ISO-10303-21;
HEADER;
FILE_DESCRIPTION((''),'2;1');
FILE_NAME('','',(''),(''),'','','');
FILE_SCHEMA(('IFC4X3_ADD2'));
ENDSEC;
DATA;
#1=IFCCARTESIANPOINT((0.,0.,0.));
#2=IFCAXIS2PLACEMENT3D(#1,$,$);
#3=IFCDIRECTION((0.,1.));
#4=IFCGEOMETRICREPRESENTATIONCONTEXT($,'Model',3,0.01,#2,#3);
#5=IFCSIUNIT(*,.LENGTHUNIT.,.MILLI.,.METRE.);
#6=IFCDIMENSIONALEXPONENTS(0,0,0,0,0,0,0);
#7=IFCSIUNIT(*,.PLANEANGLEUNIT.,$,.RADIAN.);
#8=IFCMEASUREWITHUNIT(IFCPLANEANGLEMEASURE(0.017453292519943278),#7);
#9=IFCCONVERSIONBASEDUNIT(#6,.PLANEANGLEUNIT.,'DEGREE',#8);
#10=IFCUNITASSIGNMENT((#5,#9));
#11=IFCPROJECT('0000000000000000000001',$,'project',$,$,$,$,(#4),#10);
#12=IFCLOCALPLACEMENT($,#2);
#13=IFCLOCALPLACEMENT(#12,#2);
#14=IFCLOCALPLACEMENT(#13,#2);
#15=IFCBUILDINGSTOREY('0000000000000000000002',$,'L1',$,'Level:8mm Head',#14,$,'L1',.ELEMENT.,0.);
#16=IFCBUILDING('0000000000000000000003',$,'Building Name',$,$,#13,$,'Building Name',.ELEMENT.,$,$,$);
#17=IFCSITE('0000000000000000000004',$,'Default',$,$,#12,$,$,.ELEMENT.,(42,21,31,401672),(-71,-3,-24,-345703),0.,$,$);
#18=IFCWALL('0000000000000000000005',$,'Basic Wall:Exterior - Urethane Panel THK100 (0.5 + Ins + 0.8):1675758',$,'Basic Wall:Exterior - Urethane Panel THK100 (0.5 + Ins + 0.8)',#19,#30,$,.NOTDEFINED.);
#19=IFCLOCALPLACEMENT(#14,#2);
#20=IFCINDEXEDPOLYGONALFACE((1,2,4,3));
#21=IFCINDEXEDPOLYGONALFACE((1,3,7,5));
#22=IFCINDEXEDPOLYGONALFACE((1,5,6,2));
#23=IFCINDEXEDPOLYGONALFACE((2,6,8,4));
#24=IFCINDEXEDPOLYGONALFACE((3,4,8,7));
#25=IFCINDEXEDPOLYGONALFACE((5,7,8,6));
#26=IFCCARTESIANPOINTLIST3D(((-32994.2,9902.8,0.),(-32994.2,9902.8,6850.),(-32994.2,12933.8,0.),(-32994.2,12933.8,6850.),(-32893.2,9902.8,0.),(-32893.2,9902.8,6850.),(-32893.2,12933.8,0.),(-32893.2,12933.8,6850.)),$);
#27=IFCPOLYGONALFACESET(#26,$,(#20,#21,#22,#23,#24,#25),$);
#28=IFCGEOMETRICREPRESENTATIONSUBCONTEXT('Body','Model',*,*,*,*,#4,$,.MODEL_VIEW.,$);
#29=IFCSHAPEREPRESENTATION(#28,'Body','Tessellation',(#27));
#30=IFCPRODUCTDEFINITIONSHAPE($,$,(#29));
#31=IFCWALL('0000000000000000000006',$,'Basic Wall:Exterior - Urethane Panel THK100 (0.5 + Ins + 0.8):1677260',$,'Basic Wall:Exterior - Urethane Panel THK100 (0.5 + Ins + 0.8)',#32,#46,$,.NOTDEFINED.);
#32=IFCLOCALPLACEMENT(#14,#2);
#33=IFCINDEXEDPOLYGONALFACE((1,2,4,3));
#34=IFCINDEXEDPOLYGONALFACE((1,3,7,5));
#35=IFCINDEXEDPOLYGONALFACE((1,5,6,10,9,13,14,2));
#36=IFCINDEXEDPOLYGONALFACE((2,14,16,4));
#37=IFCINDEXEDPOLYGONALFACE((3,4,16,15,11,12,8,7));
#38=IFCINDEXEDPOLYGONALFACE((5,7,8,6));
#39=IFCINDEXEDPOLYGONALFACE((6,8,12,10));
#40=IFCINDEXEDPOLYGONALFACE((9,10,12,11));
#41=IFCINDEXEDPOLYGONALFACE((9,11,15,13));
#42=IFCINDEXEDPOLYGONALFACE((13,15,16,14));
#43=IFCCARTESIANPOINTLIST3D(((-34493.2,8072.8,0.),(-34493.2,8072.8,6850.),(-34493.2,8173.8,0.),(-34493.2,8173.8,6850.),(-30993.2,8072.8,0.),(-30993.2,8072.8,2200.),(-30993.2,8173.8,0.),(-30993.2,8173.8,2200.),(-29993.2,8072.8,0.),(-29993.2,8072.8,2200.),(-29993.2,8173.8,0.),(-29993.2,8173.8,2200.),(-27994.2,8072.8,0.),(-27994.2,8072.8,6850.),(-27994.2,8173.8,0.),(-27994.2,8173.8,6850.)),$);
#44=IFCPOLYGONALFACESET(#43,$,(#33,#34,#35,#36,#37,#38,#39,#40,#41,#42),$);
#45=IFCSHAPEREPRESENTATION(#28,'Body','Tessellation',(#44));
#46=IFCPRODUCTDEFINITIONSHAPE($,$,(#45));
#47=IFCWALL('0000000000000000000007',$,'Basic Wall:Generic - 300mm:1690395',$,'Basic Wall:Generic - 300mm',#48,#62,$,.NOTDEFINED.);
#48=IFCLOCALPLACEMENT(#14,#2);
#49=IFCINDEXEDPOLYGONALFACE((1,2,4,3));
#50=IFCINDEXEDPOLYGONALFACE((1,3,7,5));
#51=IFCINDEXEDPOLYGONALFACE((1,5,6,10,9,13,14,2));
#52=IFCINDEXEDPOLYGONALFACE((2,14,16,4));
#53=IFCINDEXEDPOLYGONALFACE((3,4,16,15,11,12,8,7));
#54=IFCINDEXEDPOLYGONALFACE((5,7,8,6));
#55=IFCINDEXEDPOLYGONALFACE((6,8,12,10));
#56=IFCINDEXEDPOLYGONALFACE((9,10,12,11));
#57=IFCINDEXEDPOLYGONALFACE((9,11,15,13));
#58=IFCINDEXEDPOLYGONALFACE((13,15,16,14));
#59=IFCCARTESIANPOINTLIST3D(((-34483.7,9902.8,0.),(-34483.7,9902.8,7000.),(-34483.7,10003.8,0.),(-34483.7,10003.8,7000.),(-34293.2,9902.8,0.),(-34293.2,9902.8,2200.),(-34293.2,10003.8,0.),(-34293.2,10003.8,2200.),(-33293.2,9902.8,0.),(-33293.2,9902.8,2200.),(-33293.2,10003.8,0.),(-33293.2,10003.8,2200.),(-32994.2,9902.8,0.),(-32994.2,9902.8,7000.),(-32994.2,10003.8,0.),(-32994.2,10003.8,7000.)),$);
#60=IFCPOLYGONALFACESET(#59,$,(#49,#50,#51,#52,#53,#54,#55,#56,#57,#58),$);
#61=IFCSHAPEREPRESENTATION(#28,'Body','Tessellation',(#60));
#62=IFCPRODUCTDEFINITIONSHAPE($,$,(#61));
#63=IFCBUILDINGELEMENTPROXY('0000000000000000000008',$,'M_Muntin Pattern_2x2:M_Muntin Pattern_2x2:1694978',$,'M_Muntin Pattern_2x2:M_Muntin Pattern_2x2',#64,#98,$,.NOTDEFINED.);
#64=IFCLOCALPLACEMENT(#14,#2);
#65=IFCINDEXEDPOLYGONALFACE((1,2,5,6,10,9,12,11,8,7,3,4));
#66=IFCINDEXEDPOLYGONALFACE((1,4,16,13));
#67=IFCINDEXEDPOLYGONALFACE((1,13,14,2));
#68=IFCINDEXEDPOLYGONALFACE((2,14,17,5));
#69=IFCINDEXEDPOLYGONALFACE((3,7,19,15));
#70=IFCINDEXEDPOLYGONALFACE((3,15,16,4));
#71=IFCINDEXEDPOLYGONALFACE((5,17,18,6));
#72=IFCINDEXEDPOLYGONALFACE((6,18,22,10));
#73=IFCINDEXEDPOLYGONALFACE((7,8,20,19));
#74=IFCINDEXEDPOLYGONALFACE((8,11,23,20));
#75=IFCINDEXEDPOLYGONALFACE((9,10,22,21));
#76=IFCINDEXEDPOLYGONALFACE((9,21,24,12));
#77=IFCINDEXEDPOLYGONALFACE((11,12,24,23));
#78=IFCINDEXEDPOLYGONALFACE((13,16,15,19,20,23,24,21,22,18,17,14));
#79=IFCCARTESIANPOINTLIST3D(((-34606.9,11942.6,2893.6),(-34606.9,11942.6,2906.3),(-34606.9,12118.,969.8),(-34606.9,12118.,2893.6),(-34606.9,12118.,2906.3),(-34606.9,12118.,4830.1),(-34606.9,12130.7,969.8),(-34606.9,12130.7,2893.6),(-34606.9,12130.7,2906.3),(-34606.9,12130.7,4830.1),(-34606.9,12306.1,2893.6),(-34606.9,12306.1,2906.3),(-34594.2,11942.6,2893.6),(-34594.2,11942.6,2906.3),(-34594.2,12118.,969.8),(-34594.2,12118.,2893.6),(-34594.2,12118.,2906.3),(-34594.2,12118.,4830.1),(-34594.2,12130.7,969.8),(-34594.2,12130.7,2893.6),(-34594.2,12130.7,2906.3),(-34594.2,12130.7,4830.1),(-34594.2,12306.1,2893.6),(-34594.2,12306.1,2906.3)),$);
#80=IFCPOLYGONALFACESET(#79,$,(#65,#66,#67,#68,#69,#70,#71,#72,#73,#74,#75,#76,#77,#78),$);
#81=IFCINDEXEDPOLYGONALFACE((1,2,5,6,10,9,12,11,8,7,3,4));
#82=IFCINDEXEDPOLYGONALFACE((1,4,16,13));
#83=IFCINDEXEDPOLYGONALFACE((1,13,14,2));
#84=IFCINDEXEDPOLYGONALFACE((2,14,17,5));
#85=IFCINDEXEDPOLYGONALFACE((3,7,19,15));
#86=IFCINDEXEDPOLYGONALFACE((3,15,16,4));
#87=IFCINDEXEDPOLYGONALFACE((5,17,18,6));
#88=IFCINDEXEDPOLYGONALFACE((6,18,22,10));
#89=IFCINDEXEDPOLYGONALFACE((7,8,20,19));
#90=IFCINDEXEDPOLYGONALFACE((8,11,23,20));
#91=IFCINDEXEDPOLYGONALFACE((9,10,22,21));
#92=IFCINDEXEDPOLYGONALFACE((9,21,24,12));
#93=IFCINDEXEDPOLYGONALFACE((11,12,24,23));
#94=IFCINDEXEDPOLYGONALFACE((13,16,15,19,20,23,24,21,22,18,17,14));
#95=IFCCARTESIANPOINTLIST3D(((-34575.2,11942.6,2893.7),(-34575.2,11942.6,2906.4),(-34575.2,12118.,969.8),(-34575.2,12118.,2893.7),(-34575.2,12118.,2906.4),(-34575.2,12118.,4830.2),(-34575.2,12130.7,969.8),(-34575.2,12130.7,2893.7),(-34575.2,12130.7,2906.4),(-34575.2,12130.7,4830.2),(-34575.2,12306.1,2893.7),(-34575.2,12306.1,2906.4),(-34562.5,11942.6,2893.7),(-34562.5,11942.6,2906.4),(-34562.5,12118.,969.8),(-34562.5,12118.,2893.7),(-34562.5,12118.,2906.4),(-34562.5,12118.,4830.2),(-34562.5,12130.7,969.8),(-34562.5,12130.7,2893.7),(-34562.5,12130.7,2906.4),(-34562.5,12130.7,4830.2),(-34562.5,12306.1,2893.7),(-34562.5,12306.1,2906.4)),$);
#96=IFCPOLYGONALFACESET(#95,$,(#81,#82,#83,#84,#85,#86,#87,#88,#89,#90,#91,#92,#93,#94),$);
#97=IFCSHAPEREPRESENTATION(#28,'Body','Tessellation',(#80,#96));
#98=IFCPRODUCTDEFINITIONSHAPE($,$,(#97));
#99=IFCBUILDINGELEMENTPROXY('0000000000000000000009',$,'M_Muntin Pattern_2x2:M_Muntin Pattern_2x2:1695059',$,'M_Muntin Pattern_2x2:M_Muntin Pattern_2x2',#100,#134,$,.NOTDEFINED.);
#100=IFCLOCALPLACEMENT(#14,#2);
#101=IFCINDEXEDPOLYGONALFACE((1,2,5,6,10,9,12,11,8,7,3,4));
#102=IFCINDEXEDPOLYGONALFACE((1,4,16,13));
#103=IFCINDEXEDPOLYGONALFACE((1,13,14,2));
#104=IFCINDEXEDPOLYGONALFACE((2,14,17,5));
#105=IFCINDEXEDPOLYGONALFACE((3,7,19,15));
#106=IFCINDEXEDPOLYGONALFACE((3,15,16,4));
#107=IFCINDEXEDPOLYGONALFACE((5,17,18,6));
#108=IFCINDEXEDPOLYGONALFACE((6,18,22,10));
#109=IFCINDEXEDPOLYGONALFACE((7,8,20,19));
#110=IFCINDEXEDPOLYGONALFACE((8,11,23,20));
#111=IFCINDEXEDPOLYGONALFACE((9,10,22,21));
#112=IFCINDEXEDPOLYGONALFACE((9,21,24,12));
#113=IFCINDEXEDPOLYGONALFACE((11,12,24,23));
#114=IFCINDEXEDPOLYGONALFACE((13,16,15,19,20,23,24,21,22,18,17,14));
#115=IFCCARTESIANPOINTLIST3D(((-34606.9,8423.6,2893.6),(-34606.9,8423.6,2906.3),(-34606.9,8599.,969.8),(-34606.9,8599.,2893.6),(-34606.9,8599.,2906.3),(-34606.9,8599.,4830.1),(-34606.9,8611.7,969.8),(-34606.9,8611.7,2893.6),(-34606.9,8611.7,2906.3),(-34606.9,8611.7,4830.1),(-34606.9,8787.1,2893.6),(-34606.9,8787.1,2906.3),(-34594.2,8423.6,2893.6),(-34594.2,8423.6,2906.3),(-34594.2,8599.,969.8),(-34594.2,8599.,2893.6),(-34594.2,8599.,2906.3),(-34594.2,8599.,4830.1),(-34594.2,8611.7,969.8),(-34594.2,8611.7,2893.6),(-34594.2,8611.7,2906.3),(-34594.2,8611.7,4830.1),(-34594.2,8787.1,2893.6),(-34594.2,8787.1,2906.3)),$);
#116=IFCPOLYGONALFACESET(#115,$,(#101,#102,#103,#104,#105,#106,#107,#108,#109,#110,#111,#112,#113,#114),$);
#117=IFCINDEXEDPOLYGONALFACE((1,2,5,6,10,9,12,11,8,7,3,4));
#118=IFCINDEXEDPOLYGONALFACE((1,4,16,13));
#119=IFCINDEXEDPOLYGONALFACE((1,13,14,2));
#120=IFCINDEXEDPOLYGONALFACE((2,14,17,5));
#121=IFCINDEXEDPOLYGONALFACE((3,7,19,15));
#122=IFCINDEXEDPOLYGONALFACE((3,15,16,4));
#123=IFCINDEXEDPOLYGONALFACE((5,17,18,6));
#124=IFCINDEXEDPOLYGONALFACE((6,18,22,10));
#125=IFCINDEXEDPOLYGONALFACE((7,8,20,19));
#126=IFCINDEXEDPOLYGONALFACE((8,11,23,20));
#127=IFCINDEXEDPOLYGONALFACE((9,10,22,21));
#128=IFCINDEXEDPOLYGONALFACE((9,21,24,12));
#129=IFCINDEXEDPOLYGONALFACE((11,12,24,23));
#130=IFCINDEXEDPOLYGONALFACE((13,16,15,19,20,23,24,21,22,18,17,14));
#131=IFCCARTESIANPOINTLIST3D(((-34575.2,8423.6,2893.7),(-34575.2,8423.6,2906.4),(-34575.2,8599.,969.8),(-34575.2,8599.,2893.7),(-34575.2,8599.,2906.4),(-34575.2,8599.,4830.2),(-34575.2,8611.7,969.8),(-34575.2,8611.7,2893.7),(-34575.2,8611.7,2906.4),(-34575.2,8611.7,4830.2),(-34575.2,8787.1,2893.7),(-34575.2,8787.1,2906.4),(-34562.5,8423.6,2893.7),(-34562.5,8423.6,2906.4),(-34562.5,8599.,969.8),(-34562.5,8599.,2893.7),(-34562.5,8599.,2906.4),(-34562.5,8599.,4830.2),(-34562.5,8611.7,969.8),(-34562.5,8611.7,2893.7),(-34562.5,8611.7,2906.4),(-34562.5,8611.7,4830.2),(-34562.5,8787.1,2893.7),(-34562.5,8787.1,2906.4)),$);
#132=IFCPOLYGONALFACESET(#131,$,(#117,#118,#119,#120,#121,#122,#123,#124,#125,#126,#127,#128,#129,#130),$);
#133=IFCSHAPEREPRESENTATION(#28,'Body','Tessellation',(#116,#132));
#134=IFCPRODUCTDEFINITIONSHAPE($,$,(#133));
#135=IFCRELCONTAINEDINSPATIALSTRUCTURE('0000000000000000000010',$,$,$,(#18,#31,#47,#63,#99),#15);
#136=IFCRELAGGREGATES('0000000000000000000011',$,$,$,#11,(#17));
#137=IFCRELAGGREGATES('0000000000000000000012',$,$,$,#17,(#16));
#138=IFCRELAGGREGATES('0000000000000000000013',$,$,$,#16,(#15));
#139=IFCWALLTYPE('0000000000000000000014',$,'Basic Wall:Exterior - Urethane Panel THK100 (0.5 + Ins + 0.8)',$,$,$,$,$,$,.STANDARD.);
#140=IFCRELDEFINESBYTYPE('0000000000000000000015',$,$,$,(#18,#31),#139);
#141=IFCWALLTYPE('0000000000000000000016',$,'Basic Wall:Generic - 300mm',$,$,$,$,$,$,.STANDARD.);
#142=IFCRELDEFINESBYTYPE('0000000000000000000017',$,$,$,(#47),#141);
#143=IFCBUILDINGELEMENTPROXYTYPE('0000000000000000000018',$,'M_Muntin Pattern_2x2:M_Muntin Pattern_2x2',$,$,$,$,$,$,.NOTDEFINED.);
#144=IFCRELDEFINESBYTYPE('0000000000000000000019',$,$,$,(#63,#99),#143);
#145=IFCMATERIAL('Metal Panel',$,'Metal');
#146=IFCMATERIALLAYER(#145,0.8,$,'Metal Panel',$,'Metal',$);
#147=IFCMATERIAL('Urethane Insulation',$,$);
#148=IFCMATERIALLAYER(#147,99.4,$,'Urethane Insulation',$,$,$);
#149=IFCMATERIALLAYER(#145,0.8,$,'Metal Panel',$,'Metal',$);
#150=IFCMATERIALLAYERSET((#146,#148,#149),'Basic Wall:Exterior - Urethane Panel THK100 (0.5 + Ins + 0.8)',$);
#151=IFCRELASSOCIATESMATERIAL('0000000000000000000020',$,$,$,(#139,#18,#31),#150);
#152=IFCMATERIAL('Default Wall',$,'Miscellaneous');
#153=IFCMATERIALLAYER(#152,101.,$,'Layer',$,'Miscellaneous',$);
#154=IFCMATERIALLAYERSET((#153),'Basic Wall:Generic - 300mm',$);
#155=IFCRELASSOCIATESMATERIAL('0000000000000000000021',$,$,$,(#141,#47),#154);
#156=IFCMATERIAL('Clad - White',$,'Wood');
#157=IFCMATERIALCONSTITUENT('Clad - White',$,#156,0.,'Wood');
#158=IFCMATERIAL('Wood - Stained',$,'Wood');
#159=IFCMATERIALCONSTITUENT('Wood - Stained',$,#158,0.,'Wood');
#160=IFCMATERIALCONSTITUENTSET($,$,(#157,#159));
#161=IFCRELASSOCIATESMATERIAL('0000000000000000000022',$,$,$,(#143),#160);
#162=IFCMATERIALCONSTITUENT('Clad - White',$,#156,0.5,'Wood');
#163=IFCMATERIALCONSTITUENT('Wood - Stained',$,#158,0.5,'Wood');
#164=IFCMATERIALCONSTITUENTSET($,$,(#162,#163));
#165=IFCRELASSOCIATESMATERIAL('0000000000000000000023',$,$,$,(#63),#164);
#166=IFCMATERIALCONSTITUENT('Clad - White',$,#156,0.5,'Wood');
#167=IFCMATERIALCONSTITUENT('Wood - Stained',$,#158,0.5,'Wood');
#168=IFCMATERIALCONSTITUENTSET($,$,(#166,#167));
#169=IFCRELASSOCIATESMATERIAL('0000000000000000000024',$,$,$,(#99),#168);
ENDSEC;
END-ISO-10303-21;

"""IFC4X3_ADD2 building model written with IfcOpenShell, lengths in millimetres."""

from ifc_helpers import new_model, entity, si_unit, converted_unit, direction, frame, frame_2d, origin, place, context, subcontext, project, spatial, polyline, rectangle, outline, extrude, clip, bounded_halfspace, source, transform, mapped, material, layer, layer_set, constituent, constituent_set, type_object, type_shapes, element, save


model = new_model("IFC4X3_ADD2")

# Units and contexts
model_context = context("Model", 3, precision=0.01, world=origin(), true_north=direction((0.0, 1.0)))
body_context = subcontext(model_context, "Body", "Model", "MODEL_VIEW")
ifc_project = project(units=[si_unit("LENGTHUNIT", "METRE", prefix="MILLI"), converted_unit("PLANEANGLEUNIT", "DEGREE", entity("IfcPlaneAngleMeasure", 0.017453292519943278), si_unit("PLANEANGLEUNIT", "RADIAN"), dimensions=[0, 0, 0, 0, 0, 0, 0])], contexts=[model_context])

# Site, building, storey
site_placement = place(None, origin())
site = spatial("IfcSite", under=ifc_project, at=site_placement, Name="Default", CompositionType="ELEMENT", RefLatitude=(42, 21, 31, 401672), RefLongitude=(-71, -3, -24, -345703), RefElevation=0.0)
building_placement = place(site_placement, origin())
building = spatial("IfcBuilding", under=site, at=building_placement, Name="Building Name", LongName="Building Name", CompositionType="ELEMENT")
storey_placement = place(building_placement, origin())
storey = spatial("IfcBuildingStorey", under=building, at=storey_placement, Name="L1", ObjectType="Level:8mm Head", LongName="L1", CompositionType="ELEMENT", Elevation=0.0)

# Wall
ifc_material_1 = material(Name="Metal Panel", Category="Metal")
ifc_layer_1 = layer(ifc_material_1, 0.8, Name="Metal Panel", Category="Metal")
ifc_material_2 = material(Name="Urethane Insulation")
ifc_layer_2 = layer(ifc_material_2, 99.4, Name="Urethane Insulation")
ifc_layer_3 = layer(ifc_material_1, 0.8, Name="Metal Panel", Category="Metal")
ifc_layer_set_1 = layer_set([ifc_layer_1, ifc_layer_2, ifc_layer_3], Name="Basic Wall:Exterior - Urethane Panel THK100 (0.5 + Ins + 0.8)")
wall_type_1 = type_object("IfcWallType", Name="Basic Wall:Exterior - Urethane Panel THK100 (0.5 + Ins + 0.8)", PredefinedType="STANDARD", material=ifc_layer_set_1)
wall_1_placement = place(storey_placement, frame((-32943.7, 9902.8, 0.0), z_axis=(0.0, 0.0, 1.0), x_axis=(0.0, 1.0, 0.0)))
element("IfcWall", 1, at=wall_1_placement, inside=storey, type_object=wall_type_1, material=ifc_layer_set_1, Name="Basic Wall:Exterior - Urethane Panel THK100 (0.5 + Ins + 0.8):1675758", ObjectType="Basic Wall:Exterior - Urethane Panel THK100 (0.5 + Ins + 0.8)", PredefinedType="NOTDEFINED", context=body_context, shape_type="Clipping", body=[
    clip(extrude(rectangle(XDim=3031.0, YDim=101.0, at=frame_2d((1515.5, 0.0), x_axis=(-1.0, 0.0))), origin(), (0.0, 0.0, 1.0), 6850.0), bounded_halfspace(frame((0.0, -50.5, 6850.0), z_axis=(0.0, 0.0, -1.0), x_axis=(0.0, -1.0, 0.0)), True, frame((0.0, -50.5, 6850.0)), polyline([(0.0, 0.0), (2930.0, 0.0), (3031.0, 0.0), (3031.0, 101.0), (0.0, 101.0), (0.0, 0.0)]))),
])

# Walls, openings
wall_2_placement = place(storey_placement, frame((-34493.2, 8123.3, 0.0)))
wall_2 = element("IfcWall", 2, at=wall_2_placement, inside=storey, type_object=wall_type_1, material=ifc_layer_set_1, Name="Basic Wall:Exterior - Urethane Panel THK100 (0.5 + Ins + 0.8):1677260", ObjectType="Basic Wall:Exterior - Urethane Panel THK100 (0.5 + Ins + 0.8)", PredefinedType="NOTDEFINED", context=body_context, shape_type="Clipping", body=[
    clip(extrude(rectangle(XDim=6499.0, YDim=101.0, at=frame_2d((3249.5, 0.0), x_axis=(-1.0, 0.0))), origin(), (0.0, 0.0, 1.0), 6850.0), bounded_halfspace(frame((0.0, -50.5, 6850.0), z_axis=(0.0, 0.0, -1.0), x_axis=(1.0, 0.0, 0.0)), True, frame((0.0, -50.5, 6850.0)), polyline([(0.0, 0.0), (6499.0, 0.0), (6499.0, 101.0), (3300.0, 101.0), (3199.0, 101.0), (0.0, 101.0), (0.0, 0.0)]))),
])
opening_1_placement = place(wall_2_placement, frame((4500.0, 50.5, 0.0)))
element("IfcOpeningElement", 3, at=opening_1_placement, cuts=wall_2, PredefinedType="OPENING", context=body_context, shape_type="SweptSolid", body=[
    extrude(rectangle(XDim=2200.0, YDim=1000.0, at=frame_2d((1100.0, 500.0), x_axis=(1.0, 0.0))), frame((0.0, 0.0, 0.0), z_axis=(0.0, -1.0, 0.0), x_axis=(0.0, 0.0, 1.0)), (0.0, 0.0, 1.0), 101.0),
])
ifc_material_3 = material(Name="Default Wall", Category="Miscellaneous")
ifc_layer_4 = layer(ifc_material_3, 101.0, Name="Layer", Category="Miscellaneous")
ifc_layer_set_2 = layer_set([ifc_layer_4], Name="Basic Wall:Generic - 300mm")
wall_type_2 = type_object("IfcWallType", Name="Basic Wall:Generic - 300mm", PredefinedType="STANDARD", material=ifc_layer_set_2)
wall_3_placement = place(storey_placement, frame((-34483.7, 9953.3, 0.0)))
wall_3 = element("IfcWall", 4, at=wall_3_placement, inside=storey, type_object=wall_type_2, material=ifc_layer_set_2, Name="Basic Wall:Generic - 300mm:1690395", ObjectType="Basic Wall:Generic - 300mm", PredefinedType="NOTDEFINED", context=body_context, shape_type="SweptSolid", body=[
    extrude(rectangle(XDim=1489.5, YDim=101.0, at=frame_2d((744.7, 0.0), x_axis=(1.0, 0.0))), origin(), (0.0, 0.0, 1.0), 7000.0),
])
opening_2_placement = place(wall_3_placement, frame((190.5, -50.5, 0.0)))
element("IfcOpeningElement", 5, at=opening_2_placement, cuts=wall_3, PredefinedType="OPENING", context=body_context, shape_type="SweptSolid", body=[
    extrude(rectangle(XDim=2200.0, YDim=1000.0, at=frame_2d((1100.0, 500.0), x_axis=(1.0, 0.0))), frame((0.0, 0.0, 0.0), z_axis=(0.0, 1.0, 0.0), x_axis=(0.0, 0.0, 1.0)), (0.0, 0.0, 1.0), 101.0),
])

# Building element proxies
ifc_material_4 = material(Name="Clad - White", Category="Wood")
ifc_constituent_1 = constituent(ifc_material_4, Name="Clad - White", Category="Wood", fraction=0.5)
ifc_material_5 = material(Name="Wood - Stained", Category="Wood")
ifc_constituent_2 = constituent(ifc_material_5, Name="Wood - Stained", Category="Wood", fraction=0.5)
ifc_constituent_set_1 = constituent_set(constituents=[ifc_constituent_1, ifc_constituent_2])
ifc_constituent_3 = constituent(ifc_material_4, Name="Clad - White", Category="Wood", fraction=0.0)
ifc_constituent_4 = constituent(ifc_material_5, Name="Wood - Stained", Category="Wood", fraction=0.0)
ifc_constituent_set_2 = constituent_set(constituents=[ifc_constituent_3, ifc_constituent_4])
building_element_proxy_type_1 = type_object("IfcBuildingElementProxyType", Name="M_Muntin Pattern_2x2:M_Muntin Pattern_2x2", PredefinedType="NOTDEFINED", material=ifc_constituent_set_2)
shared_shape_1 = source(origin(), body_context, "Body", "SweptSolid", [
    extrude(outline(polyline([(6.4, -6.4), (1930.1, -6.4), (1930.1, 6.3), (6.4, 6.3), (6.4, 181.7), (-6.3, 181.7), (-6.3, 6.3), (-1930.2, 6.3), (-1930.2, -6.4), (-6.3, -6.4), (-6.3, -181.7), (6.4, -181.7), (6.4, -6.4)])), frame((0.0, 9.5, 1930.1), z_axis=(0.0, 1.0, 0.0), x_axis=(0.0, 0.0, 1.0)), (0.0, 0.0, 1.0), 12.7),
    extrude(outline(polyline([(6.4, -6.4), (1930.2, -6.4), (1930.2, 6.3), (6.4, 6.3), (6.4, 181.7), (-6.3, 181.7), (-6.3, 6.3), (-1930.2, 6.3), (-1930.2, -6.4), (-6.3, -6.4), (-6.3, -181.7), (6.4, -181.7), (6.4, -6.4)])), frame((0.0, -22.2, 1930.2), z_axis=(0.0, 1.0, 0.0), x_axis=(0.0, 0.0, 1.0)), (0.0, 0.0, 1.0), 12.7),
])
type_shapes(building_element_proxy_type_1, [shared_shape_1])
proxy_1_placement = place(storey_placement, frame((-34584.7, 12124.4, 969.8), z_axis=(0.0, 0.0, 1.0), x_axis=(0.0, 1.0, 0.0)))
element("IfcBuildingElementProxy", 6, at=proxy_1_placement, inside=storey, type_object=building_element_proxy_type_1, material=ifc_constituent_set_1, Name="M_Muntin Pattern_2x2:M_Muntin Pattern_2x2:1694978", ObjectType="M_Muntin Pattern_2x2:M_Muntin Pattern_2x2", PredefinedType="NOTDEFINED", context=body_context, shape_type="MappedRepresentation", body=[
    mapped(shared_shape_1, transform((0.0, 0.0, 0.0), scale=1.0)),
])
ifc_constituent_5 = constituent(ifc_material_4, Name="Clad - White", Category="Wood", fraction=0.5)
ifc_constituent_6 = constituent(ifc_material_5, Name="Wood - Stained", Category="Wood", fraction=0.5)
ifc_constituent_set_3 = constituent_set(constituents=[ifc_constituent_5, ifc_constituent_6])
proxy_2_placement = place(storey_placement, frame((-34584.7, 8605.4, 969.8), z_axis=(0.0, 0.0, 1.0), x_axis=(0.0, 1.0, 0.0)))
element("IfcBuildingElementProxy", 7, at=proxy_2_placement, inside=storey, type_object=building_element_proxy_type_1, material=ifc_constituent_set_3, Name="M_Muntin Pattern_2x2:M_Muntin Pattern_2x2:1695059", ObjectType="M_Muntin Pattern_2x2:M_Muntin Pattern_2x2", PredefinedType="NOTDEFINED", context=body_context, shape_type="MappedRepresentation", body=[
    mapped(shared_shape_1, transform((0.0, 0.0, 0.0), scale=1.0)),
])

save(model, "model.ifc")
